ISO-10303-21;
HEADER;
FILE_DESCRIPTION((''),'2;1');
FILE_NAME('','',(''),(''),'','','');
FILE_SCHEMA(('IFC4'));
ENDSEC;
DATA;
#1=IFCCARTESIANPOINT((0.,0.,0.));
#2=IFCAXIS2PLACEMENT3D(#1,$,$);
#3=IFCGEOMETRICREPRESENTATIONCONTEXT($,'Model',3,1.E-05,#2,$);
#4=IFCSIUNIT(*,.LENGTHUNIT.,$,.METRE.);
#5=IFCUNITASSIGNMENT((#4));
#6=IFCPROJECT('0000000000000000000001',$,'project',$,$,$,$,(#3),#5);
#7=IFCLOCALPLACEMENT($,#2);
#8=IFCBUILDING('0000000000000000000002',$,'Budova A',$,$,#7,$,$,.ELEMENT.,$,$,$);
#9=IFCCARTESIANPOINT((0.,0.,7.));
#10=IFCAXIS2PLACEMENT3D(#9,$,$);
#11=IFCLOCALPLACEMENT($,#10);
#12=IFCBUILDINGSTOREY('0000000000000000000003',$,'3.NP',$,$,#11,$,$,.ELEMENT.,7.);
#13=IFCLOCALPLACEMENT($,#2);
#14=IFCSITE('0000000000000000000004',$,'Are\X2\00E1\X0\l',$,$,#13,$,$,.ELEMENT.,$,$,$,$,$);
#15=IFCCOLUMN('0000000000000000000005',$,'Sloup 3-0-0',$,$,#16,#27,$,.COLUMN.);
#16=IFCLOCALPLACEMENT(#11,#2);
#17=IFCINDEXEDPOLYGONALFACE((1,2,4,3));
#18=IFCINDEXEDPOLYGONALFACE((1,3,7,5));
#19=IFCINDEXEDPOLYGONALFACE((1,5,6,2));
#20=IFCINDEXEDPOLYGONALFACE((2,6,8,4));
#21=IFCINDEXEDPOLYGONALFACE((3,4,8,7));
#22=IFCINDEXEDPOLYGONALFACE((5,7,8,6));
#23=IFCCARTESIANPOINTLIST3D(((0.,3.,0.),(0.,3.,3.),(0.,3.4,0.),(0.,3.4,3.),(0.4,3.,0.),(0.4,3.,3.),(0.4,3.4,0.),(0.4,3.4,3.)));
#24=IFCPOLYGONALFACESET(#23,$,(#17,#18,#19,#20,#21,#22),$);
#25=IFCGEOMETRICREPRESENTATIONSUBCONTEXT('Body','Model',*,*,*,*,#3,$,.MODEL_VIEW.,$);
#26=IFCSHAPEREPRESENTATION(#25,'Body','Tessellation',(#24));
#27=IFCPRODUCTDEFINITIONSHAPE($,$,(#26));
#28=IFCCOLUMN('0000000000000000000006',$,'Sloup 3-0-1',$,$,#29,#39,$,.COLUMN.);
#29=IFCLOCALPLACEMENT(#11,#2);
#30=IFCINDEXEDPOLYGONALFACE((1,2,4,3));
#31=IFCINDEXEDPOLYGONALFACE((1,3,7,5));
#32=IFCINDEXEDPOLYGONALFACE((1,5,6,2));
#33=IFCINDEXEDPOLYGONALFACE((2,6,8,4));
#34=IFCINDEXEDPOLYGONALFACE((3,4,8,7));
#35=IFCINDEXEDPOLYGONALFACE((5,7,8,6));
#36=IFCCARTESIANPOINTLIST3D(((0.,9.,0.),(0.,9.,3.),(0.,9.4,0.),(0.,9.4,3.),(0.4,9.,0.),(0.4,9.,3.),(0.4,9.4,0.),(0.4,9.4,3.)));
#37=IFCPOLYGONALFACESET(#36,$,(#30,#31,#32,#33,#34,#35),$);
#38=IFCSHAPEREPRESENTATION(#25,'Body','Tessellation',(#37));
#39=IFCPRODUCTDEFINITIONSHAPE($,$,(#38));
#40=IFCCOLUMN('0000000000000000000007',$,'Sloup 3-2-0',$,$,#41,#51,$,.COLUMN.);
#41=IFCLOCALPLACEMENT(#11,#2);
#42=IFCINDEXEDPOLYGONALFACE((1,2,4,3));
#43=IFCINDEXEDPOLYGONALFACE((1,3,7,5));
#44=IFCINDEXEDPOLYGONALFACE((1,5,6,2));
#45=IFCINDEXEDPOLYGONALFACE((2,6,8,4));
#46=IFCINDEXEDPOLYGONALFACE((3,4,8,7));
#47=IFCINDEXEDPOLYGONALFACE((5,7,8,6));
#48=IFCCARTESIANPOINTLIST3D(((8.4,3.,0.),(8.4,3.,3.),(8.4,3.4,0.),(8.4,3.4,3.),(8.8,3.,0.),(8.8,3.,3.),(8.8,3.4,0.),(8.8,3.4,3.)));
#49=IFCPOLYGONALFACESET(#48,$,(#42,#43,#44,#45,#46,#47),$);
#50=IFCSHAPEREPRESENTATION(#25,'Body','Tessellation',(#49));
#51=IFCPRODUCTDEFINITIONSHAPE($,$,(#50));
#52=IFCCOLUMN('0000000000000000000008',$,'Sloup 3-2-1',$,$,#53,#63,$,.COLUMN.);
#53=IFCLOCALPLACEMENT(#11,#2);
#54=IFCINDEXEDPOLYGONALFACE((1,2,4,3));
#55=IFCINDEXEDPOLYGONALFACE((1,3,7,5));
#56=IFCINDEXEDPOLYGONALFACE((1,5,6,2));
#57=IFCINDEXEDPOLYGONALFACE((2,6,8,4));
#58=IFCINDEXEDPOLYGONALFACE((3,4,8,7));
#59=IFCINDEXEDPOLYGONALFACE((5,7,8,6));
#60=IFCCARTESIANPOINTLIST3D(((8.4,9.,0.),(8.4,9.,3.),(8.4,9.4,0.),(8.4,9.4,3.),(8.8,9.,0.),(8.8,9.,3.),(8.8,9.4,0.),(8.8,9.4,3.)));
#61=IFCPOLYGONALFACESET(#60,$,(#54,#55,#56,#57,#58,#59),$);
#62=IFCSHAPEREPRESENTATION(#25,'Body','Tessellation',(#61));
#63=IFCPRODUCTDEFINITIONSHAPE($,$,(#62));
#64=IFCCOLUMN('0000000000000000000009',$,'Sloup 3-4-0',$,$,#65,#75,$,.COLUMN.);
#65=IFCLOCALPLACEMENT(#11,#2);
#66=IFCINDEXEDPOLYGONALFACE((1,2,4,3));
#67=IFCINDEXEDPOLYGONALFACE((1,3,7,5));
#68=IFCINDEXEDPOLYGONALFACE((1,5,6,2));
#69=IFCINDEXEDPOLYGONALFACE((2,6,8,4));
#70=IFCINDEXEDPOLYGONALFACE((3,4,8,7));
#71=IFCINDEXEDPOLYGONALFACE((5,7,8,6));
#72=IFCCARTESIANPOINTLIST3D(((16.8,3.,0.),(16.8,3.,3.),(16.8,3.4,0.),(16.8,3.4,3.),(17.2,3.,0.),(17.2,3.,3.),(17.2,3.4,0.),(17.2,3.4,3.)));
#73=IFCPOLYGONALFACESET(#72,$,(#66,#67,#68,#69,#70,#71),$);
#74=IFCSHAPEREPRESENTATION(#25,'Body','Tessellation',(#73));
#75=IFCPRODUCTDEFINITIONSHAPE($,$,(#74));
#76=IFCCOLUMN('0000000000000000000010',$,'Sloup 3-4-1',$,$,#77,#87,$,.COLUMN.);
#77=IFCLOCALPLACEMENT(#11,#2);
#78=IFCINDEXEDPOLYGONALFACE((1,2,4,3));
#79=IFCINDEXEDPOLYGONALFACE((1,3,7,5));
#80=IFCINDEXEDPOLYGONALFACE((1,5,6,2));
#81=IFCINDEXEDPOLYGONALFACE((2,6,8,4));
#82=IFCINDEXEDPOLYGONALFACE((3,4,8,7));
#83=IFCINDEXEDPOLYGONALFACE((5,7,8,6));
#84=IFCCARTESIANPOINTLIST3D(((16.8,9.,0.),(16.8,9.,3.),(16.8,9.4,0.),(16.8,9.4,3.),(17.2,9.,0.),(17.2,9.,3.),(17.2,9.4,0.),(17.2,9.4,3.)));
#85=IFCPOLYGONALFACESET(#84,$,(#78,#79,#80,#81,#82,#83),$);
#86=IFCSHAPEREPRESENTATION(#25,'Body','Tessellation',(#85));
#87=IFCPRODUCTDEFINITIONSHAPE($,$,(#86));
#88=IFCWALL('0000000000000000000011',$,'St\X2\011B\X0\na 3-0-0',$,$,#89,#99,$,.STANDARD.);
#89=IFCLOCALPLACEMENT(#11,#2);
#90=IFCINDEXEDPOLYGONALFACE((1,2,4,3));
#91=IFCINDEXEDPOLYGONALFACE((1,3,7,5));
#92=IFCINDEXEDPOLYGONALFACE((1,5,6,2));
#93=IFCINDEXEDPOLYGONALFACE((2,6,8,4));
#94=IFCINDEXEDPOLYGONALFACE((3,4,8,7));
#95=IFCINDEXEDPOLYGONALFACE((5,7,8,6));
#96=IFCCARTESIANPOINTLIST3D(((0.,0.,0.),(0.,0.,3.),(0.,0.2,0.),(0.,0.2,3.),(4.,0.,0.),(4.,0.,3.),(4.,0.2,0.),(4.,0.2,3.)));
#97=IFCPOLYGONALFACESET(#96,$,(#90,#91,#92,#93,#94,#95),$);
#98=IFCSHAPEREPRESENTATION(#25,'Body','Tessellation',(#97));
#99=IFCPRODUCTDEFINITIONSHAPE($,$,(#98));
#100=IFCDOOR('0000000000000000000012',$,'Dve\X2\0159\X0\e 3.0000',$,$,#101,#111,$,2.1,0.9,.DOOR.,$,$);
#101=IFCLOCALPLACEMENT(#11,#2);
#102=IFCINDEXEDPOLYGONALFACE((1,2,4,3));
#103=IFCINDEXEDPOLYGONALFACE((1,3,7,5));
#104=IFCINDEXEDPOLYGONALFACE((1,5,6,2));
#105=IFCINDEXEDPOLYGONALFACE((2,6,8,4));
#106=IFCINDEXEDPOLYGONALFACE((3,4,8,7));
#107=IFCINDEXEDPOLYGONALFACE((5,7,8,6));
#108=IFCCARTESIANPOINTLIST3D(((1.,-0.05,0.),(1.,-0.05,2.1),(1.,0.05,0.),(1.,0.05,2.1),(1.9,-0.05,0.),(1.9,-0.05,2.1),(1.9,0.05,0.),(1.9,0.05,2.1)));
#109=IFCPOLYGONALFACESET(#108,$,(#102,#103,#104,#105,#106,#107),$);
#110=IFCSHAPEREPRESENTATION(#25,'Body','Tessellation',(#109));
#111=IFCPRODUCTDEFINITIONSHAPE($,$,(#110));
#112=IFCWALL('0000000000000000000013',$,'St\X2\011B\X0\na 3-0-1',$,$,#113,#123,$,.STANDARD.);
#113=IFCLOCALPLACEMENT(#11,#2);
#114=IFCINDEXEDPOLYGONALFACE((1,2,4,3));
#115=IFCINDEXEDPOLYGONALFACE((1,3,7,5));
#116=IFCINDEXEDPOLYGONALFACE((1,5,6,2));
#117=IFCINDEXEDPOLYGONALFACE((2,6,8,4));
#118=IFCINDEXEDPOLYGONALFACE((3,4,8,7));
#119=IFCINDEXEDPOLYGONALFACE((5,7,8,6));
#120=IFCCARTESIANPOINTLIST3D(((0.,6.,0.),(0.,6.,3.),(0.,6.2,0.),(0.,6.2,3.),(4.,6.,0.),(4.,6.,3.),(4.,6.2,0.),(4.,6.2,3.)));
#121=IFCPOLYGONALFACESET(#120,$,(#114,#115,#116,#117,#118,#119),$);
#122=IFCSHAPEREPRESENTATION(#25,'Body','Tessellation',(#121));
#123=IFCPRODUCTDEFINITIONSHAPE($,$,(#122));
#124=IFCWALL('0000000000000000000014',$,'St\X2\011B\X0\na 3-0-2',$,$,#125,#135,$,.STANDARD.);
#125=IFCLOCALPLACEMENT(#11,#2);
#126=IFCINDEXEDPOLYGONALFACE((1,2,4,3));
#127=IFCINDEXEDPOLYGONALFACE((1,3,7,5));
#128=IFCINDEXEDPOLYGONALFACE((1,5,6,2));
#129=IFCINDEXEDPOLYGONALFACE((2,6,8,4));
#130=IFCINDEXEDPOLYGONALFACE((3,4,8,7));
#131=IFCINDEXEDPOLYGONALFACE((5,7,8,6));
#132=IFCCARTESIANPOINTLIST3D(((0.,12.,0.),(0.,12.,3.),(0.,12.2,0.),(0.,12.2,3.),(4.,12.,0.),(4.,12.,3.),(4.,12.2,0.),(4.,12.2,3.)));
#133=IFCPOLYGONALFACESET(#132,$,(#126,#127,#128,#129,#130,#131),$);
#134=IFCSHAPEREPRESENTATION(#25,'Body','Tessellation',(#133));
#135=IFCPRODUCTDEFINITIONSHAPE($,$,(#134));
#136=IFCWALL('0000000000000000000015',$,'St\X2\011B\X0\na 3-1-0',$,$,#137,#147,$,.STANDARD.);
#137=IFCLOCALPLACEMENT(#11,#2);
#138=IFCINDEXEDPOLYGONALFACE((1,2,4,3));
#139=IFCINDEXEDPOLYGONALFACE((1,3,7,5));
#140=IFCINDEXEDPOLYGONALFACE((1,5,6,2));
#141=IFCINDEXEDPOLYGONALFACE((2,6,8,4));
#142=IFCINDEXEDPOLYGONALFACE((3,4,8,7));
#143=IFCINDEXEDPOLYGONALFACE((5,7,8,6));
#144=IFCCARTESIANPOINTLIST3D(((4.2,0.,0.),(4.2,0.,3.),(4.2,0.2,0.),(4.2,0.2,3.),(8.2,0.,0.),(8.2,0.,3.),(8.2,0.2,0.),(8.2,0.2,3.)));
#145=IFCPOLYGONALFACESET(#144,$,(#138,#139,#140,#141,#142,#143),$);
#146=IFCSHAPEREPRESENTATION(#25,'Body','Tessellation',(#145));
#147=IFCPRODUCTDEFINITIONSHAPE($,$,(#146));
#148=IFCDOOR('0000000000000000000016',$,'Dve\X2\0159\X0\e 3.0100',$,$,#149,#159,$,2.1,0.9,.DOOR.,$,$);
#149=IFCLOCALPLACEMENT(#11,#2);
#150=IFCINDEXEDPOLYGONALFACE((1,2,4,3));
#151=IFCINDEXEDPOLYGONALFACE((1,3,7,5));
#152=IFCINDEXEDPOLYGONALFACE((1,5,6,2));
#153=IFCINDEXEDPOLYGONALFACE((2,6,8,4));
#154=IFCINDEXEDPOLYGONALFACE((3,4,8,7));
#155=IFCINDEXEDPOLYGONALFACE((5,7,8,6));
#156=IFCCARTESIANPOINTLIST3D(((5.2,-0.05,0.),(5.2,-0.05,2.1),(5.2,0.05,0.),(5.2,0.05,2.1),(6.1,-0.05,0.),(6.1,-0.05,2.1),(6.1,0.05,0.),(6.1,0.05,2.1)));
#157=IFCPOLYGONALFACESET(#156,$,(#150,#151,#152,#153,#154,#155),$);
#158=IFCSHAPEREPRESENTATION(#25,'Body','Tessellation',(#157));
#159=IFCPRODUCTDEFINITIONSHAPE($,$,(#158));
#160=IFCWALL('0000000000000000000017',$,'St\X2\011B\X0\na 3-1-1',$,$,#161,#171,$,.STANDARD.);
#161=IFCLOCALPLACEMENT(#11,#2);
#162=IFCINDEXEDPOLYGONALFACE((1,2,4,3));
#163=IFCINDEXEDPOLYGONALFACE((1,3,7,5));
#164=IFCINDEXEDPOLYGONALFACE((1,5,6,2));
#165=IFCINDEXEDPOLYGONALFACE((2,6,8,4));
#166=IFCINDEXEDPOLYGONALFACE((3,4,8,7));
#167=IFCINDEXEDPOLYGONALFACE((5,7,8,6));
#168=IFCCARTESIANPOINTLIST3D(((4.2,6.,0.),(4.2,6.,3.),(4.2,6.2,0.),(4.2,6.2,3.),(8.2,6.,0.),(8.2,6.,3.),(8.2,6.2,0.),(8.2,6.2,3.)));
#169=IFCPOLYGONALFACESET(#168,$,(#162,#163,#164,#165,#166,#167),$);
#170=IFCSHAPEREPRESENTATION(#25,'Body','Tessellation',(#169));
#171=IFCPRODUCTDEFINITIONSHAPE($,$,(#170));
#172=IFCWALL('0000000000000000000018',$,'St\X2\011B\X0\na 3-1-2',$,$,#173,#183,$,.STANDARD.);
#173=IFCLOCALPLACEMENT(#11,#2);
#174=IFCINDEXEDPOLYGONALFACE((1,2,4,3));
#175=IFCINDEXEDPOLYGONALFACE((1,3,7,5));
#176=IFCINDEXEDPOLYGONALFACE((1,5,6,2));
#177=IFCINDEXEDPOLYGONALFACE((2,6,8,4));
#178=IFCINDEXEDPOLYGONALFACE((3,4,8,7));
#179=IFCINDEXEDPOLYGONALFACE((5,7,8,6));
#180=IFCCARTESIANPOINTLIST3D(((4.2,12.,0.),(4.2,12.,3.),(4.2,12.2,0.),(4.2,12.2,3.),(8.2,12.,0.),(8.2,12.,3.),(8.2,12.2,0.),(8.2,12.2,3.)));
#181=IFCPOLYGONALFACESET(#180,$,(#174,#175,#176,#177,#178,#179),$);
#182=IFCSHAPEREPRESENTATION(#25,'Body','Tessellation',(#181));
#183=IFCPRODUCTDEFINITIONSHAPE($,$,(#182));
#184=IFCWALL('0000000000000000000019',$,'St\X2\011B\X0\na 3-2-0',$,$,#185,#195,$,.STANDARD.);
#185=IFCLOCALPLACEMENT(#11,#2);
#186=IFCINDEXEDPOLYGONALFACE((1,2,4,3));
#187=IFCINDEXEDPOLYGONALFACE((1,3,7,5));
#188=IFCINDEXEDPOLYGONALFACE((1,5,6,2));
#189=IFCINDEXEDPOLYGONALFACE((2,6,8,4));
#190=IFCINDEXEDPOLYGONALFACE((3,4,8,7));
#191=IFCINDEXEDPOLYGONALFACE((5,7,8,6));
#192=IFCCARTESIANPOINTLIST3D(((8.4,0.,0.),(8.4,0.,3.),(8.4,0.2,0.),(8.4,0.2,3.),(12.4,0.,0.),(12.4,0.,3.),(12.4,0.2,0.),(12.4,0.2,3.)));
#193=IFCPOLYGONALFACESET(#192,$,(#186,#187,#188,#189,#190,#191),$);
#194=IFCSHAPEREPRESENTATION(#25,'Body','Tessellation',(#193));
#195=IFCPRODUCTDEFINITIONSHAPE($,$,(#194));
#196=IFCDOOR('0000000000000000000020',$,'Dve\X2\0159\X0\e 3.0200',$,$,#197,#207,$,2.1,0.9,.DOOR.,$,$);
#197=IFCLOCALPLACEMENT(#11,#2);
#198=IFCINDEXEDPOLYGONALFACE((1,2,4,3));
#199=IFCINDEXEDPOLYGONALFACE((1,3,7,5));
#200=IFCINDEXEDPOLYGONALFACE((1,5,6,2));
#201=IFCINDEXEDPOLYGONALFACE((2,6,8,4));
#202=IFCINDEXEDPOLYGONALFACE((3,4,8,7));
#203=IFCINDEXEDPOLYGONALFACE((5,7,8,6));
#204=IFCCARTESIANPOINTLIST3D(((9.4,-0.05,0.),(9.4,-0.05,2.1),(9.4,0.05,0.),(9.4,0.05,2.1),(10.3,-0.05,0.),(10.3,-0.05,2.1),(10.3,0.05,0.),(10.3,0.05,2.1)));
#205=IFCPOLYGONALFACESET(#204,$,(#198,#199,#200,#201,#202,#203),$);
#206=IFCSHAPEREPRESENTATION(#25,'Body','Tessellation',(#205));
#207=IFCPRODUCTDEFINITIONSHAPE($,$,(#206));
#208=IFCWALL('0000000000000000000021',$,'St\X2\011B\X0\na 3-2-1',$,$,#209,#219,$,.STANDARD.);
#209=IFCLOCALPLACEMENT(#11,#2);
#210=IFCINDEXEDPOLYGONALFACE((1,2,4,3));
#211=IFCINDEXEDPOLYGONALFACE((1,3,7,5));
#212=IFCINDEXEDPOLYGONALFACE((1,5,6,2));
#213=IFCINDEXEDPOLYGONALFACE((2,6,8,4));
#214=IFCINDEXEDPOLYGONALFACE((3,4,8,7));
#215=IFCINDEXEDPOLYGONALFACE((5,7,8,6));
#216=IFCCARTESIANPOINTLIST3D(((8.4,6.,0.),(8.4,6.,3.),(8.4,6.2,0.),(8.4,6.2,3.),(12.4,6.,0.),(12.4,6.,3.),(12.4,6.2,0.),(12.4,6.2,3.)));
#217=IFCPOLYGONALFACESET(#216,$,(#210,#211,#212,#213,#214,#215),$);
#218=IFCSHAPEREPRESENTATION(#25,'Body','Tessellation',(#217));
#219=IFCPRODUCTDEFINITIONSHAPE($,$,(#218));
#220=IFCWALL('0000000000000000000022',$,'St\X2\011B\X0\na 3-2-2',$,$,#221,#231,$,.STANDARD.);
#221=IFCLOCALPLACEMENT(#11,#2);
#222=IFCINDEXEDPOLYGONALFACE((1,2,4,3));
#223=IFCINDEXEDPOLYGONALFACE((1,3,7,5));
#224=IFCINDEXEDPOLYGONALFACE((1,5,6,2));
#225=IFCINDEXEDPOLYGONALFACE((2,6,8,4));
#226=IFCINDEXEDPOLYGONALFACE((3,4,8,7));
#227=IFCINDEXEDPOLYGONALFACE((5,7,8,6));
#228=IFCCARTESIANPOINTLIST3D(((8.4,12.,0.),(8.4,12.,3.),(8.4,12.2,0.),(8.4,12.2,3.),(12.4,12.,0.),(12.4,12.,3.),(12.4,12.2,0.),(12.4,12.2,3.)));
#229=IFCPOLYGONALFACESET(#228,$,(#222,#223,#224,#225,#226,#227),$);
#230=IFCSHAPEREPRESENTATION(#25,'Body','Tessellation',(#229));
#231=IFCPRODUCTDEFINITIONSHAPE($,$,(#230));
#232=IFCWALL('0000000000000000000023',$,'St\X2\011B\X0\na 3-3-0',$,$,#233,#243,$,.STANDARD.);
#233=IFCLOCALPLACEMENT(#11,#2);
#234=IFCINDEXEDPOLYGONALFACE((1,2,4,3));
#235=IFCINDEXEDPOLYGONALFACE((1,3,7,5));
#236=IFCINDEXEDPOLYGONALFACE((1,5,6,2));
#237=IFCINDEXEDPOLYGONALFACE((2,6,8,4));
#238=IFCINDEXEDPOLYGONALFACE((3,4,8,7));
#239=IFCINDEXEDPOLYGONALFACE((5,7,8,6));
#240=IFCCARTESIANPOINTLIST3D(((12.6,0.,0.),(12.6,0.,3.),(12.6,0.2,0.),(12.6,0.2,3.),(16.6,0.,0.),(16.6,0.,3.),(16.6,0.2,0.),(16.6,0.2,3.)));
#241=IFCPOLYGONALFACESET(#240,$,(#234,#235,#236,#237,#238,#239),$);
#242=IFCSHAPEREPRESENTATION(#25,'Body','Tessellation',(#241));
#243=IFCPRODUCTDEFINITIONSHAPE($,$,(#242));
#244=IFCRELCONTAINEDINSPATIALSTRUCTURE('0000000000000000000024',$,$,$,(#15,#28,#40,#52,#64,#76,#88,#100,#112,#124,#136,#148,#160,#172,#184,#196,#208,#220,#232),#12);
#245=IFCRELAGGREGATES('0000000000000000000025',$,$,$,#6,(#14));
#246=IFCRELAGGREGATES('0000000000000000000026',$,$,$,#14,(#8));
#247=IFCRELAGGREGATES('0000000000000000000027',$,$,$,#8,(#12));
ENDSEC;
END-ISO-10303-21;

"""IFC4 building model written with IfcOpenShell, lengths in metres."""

from ifc_helpers import new_model, si_unit, frame, frame_2d, origin, place, context, subcontext, project, spatial, rectangle, extrude, element, save


model = new_model("IFC4")

# Units and contexts
model_context = context("Model", 3, precision=1e-05, world=origin())
body_context = subcontext(model_context, "Body", "Model", "MODEL_VIEW")
ifc_project = project(units=[si_unit("LENGTHUNIT", "METRE")], contexts=[model_context])

# Site, building, storey
site_placement = place(None, origin())
site = spatial("IfcSite", under=ifc_project, at=site_placement, Name="Areál", CompositionType="ELEMENT")
building_placement = place(None, origin())
building = spatial("IfcBuilding", under=site, at=building_placement, Name="Budova A", CompositionType="ELEMENT")
storey_placement = place(None, frame((0.0, 0.0, 7.0)))
storey = spatial("IfcBuildingStorey", under=building, at=storey_placement, Name="3.NP", CompositionType="ELEMENT", Elevation=7.0)

# Columns
for number, where, name in (
    (1, (0.0, 3.0, 0.0), "Sloup 3-0-0"),
    (2, (0.0, 9.0, 0.0), "Sloup 3-0-1"),
    (3, (8.4, 3.0, 0.0), "Sloup 3-2-0"),
    (4, (8.4, 9.0, 0.0), "Sloup 3-2-1"),
    (5, (16.8, 3.0, 0.0), "Sloup 3-4-0"),
    (6, (16.8, 9.0, 0.0), "Sloup 3-4-1"),
):
    element("IfcColumn", number, at=place(storey_placement, frame(where)), inside=storey, Name=name, PredefinedType="COLUMN", context=body_context, shape_type="SweptSolid", body=[
        extrude(rectangle(XDim=0.4, YDim=0.4, at=frame_2d((0.2, 0.2))), origin(), (0.0, 0.0, 1.0), 3.0),
    ])

# Wall
wall_1_placement = place(storey_placement, origin())
element("IfcWall", 7, at=wall_1_placement, inside=storey, Name="Stěna 3-0-0", PredefinedType="STANDARD", context=body_context, shape_type="SweptSolid", body=[
    extrude(rectangle(XDim=4.0, YDim=0.2, at=frame_2d((2.0, 0.1))), origin(), (0.0, 0.0, 1.0), 3.0),
])

# Door
door_1_placement = place(storey_placement, frame((1.0, -0.05, 0.0)))
element("IfcDoor", 8, at=door_1_placement, inside=storey, Name="Dveře 3.0000", OverallHeight=2.1, OverallWidth=0.9, PredefinedType="DOOR", context=body_context, shape_type="SweptSolid", body=[
    extrude(rectangle(XDim=0.9, YDim=0.1, at=frame_2d((0.45, 0.05))), origin(), (0.0, 0.0, 1.0), 2.1),
])

# Walls
for number, where, name in (
    (9, (0.0, 6.0, 0.0), "Stěna 3-0-1"),
    (10, (0.0, 12.0, 0.0), "Stěna 3-0-2"),
    (11, (4.2, 0.0, 0.0), "Stěna 3-1-0"),
):
    element("IfcWall", number, at=place(storey_placement, frame(where)), inside=storey, Name=name, PredefinedType="STANDARD", context=body_context, shape_type="SweptSolid", body=[
        extrude(rectangle(XDim=4.0, YDim=0.2, at=frame_2d((2.0, 0.1))), origin(), (0.0, 0.0, 1.0), 3.0),
    ])

# Door
door_2_placement = place(storey_placement, frame((5.2, -0.05, 0.0)))
element("IfcDoor", 12, at=door_2_placement, inside=storey, Name="Dveře 3.0100", OverallHeight=2.1, OverallWidth=0.9, PredefinedType="DOOR", context=body_context, shape_type="SweptSolid", body=[
    extrude(rectangle(XDim=0.9, YDim=0.1, at=frame_2d((0.45, 0.05))), origin(), (0.0, 0.0, 1.0), 2.1),
])

# Walls
for number, where, name in (
    (13, (4.2, 6.0, 0.0), "Stěna 3-1-1"),
    (14, (4.2, 12.0, 0.0), "Stěna 3-1-2"),
    (15, (8.4, 0.0, 0.0), "Stěna 3-2-0"),
):
    element("IfcWall", number, at=place(storey_placement, frame(where)), inside=storey, Name=name, PredefinedType="STANDARD", context=body_context, shape_type="SweptSolid", body=[
        extrude(rectangle(XDim=4.0, YDim=0.2, at=frame_2d((2.0, 0.1))), origin(), (0.0, 0.0, 1.0), 3.0),
    ])

# Door
door_3_placement = place(storey_placement, frame((9.4, -0.05, 0.0)))
element("IfcDoor", 16, at=door_3_placement, inside=storey, Name="Dveře 3.0200", OverallHeight=2.1, OverallWidth=0.9, PredefinedType="DOOR", context=body_context, shape_type="SweptSolid", body=[
    extrude(rectangle(XDim=0.9, YDim=0.1, at=frame_2d((0.45, 0.05))), origin(), (0.0, 0.0, 1.0), 2.1),
])

# Walls
for number, where, name in (
    (17, (8.4, 6.0, 0.0), "Stěna 3-2-1"),
    (18, (8.4, 12.0, 0.0), "Stěna 3-2-2"),
    (19, (12.6, 0.0, 0.0), "Stěna 3-3-0"),
):
    element("IfcWall", number, at=place(storey_placement, frame(where)), inside=storey, Name=name, PredefinedType="STANDARD", context=body_context, shape_type="SweptSolid", body=[
        extrude(rectangle(XDim=4.0, YDim=0.2, at=frame_2d((2.0, 0.1))), origin(), (0.0, 0.0, 1.0), 3.0),
    ])

save(model, "model.ifc")
